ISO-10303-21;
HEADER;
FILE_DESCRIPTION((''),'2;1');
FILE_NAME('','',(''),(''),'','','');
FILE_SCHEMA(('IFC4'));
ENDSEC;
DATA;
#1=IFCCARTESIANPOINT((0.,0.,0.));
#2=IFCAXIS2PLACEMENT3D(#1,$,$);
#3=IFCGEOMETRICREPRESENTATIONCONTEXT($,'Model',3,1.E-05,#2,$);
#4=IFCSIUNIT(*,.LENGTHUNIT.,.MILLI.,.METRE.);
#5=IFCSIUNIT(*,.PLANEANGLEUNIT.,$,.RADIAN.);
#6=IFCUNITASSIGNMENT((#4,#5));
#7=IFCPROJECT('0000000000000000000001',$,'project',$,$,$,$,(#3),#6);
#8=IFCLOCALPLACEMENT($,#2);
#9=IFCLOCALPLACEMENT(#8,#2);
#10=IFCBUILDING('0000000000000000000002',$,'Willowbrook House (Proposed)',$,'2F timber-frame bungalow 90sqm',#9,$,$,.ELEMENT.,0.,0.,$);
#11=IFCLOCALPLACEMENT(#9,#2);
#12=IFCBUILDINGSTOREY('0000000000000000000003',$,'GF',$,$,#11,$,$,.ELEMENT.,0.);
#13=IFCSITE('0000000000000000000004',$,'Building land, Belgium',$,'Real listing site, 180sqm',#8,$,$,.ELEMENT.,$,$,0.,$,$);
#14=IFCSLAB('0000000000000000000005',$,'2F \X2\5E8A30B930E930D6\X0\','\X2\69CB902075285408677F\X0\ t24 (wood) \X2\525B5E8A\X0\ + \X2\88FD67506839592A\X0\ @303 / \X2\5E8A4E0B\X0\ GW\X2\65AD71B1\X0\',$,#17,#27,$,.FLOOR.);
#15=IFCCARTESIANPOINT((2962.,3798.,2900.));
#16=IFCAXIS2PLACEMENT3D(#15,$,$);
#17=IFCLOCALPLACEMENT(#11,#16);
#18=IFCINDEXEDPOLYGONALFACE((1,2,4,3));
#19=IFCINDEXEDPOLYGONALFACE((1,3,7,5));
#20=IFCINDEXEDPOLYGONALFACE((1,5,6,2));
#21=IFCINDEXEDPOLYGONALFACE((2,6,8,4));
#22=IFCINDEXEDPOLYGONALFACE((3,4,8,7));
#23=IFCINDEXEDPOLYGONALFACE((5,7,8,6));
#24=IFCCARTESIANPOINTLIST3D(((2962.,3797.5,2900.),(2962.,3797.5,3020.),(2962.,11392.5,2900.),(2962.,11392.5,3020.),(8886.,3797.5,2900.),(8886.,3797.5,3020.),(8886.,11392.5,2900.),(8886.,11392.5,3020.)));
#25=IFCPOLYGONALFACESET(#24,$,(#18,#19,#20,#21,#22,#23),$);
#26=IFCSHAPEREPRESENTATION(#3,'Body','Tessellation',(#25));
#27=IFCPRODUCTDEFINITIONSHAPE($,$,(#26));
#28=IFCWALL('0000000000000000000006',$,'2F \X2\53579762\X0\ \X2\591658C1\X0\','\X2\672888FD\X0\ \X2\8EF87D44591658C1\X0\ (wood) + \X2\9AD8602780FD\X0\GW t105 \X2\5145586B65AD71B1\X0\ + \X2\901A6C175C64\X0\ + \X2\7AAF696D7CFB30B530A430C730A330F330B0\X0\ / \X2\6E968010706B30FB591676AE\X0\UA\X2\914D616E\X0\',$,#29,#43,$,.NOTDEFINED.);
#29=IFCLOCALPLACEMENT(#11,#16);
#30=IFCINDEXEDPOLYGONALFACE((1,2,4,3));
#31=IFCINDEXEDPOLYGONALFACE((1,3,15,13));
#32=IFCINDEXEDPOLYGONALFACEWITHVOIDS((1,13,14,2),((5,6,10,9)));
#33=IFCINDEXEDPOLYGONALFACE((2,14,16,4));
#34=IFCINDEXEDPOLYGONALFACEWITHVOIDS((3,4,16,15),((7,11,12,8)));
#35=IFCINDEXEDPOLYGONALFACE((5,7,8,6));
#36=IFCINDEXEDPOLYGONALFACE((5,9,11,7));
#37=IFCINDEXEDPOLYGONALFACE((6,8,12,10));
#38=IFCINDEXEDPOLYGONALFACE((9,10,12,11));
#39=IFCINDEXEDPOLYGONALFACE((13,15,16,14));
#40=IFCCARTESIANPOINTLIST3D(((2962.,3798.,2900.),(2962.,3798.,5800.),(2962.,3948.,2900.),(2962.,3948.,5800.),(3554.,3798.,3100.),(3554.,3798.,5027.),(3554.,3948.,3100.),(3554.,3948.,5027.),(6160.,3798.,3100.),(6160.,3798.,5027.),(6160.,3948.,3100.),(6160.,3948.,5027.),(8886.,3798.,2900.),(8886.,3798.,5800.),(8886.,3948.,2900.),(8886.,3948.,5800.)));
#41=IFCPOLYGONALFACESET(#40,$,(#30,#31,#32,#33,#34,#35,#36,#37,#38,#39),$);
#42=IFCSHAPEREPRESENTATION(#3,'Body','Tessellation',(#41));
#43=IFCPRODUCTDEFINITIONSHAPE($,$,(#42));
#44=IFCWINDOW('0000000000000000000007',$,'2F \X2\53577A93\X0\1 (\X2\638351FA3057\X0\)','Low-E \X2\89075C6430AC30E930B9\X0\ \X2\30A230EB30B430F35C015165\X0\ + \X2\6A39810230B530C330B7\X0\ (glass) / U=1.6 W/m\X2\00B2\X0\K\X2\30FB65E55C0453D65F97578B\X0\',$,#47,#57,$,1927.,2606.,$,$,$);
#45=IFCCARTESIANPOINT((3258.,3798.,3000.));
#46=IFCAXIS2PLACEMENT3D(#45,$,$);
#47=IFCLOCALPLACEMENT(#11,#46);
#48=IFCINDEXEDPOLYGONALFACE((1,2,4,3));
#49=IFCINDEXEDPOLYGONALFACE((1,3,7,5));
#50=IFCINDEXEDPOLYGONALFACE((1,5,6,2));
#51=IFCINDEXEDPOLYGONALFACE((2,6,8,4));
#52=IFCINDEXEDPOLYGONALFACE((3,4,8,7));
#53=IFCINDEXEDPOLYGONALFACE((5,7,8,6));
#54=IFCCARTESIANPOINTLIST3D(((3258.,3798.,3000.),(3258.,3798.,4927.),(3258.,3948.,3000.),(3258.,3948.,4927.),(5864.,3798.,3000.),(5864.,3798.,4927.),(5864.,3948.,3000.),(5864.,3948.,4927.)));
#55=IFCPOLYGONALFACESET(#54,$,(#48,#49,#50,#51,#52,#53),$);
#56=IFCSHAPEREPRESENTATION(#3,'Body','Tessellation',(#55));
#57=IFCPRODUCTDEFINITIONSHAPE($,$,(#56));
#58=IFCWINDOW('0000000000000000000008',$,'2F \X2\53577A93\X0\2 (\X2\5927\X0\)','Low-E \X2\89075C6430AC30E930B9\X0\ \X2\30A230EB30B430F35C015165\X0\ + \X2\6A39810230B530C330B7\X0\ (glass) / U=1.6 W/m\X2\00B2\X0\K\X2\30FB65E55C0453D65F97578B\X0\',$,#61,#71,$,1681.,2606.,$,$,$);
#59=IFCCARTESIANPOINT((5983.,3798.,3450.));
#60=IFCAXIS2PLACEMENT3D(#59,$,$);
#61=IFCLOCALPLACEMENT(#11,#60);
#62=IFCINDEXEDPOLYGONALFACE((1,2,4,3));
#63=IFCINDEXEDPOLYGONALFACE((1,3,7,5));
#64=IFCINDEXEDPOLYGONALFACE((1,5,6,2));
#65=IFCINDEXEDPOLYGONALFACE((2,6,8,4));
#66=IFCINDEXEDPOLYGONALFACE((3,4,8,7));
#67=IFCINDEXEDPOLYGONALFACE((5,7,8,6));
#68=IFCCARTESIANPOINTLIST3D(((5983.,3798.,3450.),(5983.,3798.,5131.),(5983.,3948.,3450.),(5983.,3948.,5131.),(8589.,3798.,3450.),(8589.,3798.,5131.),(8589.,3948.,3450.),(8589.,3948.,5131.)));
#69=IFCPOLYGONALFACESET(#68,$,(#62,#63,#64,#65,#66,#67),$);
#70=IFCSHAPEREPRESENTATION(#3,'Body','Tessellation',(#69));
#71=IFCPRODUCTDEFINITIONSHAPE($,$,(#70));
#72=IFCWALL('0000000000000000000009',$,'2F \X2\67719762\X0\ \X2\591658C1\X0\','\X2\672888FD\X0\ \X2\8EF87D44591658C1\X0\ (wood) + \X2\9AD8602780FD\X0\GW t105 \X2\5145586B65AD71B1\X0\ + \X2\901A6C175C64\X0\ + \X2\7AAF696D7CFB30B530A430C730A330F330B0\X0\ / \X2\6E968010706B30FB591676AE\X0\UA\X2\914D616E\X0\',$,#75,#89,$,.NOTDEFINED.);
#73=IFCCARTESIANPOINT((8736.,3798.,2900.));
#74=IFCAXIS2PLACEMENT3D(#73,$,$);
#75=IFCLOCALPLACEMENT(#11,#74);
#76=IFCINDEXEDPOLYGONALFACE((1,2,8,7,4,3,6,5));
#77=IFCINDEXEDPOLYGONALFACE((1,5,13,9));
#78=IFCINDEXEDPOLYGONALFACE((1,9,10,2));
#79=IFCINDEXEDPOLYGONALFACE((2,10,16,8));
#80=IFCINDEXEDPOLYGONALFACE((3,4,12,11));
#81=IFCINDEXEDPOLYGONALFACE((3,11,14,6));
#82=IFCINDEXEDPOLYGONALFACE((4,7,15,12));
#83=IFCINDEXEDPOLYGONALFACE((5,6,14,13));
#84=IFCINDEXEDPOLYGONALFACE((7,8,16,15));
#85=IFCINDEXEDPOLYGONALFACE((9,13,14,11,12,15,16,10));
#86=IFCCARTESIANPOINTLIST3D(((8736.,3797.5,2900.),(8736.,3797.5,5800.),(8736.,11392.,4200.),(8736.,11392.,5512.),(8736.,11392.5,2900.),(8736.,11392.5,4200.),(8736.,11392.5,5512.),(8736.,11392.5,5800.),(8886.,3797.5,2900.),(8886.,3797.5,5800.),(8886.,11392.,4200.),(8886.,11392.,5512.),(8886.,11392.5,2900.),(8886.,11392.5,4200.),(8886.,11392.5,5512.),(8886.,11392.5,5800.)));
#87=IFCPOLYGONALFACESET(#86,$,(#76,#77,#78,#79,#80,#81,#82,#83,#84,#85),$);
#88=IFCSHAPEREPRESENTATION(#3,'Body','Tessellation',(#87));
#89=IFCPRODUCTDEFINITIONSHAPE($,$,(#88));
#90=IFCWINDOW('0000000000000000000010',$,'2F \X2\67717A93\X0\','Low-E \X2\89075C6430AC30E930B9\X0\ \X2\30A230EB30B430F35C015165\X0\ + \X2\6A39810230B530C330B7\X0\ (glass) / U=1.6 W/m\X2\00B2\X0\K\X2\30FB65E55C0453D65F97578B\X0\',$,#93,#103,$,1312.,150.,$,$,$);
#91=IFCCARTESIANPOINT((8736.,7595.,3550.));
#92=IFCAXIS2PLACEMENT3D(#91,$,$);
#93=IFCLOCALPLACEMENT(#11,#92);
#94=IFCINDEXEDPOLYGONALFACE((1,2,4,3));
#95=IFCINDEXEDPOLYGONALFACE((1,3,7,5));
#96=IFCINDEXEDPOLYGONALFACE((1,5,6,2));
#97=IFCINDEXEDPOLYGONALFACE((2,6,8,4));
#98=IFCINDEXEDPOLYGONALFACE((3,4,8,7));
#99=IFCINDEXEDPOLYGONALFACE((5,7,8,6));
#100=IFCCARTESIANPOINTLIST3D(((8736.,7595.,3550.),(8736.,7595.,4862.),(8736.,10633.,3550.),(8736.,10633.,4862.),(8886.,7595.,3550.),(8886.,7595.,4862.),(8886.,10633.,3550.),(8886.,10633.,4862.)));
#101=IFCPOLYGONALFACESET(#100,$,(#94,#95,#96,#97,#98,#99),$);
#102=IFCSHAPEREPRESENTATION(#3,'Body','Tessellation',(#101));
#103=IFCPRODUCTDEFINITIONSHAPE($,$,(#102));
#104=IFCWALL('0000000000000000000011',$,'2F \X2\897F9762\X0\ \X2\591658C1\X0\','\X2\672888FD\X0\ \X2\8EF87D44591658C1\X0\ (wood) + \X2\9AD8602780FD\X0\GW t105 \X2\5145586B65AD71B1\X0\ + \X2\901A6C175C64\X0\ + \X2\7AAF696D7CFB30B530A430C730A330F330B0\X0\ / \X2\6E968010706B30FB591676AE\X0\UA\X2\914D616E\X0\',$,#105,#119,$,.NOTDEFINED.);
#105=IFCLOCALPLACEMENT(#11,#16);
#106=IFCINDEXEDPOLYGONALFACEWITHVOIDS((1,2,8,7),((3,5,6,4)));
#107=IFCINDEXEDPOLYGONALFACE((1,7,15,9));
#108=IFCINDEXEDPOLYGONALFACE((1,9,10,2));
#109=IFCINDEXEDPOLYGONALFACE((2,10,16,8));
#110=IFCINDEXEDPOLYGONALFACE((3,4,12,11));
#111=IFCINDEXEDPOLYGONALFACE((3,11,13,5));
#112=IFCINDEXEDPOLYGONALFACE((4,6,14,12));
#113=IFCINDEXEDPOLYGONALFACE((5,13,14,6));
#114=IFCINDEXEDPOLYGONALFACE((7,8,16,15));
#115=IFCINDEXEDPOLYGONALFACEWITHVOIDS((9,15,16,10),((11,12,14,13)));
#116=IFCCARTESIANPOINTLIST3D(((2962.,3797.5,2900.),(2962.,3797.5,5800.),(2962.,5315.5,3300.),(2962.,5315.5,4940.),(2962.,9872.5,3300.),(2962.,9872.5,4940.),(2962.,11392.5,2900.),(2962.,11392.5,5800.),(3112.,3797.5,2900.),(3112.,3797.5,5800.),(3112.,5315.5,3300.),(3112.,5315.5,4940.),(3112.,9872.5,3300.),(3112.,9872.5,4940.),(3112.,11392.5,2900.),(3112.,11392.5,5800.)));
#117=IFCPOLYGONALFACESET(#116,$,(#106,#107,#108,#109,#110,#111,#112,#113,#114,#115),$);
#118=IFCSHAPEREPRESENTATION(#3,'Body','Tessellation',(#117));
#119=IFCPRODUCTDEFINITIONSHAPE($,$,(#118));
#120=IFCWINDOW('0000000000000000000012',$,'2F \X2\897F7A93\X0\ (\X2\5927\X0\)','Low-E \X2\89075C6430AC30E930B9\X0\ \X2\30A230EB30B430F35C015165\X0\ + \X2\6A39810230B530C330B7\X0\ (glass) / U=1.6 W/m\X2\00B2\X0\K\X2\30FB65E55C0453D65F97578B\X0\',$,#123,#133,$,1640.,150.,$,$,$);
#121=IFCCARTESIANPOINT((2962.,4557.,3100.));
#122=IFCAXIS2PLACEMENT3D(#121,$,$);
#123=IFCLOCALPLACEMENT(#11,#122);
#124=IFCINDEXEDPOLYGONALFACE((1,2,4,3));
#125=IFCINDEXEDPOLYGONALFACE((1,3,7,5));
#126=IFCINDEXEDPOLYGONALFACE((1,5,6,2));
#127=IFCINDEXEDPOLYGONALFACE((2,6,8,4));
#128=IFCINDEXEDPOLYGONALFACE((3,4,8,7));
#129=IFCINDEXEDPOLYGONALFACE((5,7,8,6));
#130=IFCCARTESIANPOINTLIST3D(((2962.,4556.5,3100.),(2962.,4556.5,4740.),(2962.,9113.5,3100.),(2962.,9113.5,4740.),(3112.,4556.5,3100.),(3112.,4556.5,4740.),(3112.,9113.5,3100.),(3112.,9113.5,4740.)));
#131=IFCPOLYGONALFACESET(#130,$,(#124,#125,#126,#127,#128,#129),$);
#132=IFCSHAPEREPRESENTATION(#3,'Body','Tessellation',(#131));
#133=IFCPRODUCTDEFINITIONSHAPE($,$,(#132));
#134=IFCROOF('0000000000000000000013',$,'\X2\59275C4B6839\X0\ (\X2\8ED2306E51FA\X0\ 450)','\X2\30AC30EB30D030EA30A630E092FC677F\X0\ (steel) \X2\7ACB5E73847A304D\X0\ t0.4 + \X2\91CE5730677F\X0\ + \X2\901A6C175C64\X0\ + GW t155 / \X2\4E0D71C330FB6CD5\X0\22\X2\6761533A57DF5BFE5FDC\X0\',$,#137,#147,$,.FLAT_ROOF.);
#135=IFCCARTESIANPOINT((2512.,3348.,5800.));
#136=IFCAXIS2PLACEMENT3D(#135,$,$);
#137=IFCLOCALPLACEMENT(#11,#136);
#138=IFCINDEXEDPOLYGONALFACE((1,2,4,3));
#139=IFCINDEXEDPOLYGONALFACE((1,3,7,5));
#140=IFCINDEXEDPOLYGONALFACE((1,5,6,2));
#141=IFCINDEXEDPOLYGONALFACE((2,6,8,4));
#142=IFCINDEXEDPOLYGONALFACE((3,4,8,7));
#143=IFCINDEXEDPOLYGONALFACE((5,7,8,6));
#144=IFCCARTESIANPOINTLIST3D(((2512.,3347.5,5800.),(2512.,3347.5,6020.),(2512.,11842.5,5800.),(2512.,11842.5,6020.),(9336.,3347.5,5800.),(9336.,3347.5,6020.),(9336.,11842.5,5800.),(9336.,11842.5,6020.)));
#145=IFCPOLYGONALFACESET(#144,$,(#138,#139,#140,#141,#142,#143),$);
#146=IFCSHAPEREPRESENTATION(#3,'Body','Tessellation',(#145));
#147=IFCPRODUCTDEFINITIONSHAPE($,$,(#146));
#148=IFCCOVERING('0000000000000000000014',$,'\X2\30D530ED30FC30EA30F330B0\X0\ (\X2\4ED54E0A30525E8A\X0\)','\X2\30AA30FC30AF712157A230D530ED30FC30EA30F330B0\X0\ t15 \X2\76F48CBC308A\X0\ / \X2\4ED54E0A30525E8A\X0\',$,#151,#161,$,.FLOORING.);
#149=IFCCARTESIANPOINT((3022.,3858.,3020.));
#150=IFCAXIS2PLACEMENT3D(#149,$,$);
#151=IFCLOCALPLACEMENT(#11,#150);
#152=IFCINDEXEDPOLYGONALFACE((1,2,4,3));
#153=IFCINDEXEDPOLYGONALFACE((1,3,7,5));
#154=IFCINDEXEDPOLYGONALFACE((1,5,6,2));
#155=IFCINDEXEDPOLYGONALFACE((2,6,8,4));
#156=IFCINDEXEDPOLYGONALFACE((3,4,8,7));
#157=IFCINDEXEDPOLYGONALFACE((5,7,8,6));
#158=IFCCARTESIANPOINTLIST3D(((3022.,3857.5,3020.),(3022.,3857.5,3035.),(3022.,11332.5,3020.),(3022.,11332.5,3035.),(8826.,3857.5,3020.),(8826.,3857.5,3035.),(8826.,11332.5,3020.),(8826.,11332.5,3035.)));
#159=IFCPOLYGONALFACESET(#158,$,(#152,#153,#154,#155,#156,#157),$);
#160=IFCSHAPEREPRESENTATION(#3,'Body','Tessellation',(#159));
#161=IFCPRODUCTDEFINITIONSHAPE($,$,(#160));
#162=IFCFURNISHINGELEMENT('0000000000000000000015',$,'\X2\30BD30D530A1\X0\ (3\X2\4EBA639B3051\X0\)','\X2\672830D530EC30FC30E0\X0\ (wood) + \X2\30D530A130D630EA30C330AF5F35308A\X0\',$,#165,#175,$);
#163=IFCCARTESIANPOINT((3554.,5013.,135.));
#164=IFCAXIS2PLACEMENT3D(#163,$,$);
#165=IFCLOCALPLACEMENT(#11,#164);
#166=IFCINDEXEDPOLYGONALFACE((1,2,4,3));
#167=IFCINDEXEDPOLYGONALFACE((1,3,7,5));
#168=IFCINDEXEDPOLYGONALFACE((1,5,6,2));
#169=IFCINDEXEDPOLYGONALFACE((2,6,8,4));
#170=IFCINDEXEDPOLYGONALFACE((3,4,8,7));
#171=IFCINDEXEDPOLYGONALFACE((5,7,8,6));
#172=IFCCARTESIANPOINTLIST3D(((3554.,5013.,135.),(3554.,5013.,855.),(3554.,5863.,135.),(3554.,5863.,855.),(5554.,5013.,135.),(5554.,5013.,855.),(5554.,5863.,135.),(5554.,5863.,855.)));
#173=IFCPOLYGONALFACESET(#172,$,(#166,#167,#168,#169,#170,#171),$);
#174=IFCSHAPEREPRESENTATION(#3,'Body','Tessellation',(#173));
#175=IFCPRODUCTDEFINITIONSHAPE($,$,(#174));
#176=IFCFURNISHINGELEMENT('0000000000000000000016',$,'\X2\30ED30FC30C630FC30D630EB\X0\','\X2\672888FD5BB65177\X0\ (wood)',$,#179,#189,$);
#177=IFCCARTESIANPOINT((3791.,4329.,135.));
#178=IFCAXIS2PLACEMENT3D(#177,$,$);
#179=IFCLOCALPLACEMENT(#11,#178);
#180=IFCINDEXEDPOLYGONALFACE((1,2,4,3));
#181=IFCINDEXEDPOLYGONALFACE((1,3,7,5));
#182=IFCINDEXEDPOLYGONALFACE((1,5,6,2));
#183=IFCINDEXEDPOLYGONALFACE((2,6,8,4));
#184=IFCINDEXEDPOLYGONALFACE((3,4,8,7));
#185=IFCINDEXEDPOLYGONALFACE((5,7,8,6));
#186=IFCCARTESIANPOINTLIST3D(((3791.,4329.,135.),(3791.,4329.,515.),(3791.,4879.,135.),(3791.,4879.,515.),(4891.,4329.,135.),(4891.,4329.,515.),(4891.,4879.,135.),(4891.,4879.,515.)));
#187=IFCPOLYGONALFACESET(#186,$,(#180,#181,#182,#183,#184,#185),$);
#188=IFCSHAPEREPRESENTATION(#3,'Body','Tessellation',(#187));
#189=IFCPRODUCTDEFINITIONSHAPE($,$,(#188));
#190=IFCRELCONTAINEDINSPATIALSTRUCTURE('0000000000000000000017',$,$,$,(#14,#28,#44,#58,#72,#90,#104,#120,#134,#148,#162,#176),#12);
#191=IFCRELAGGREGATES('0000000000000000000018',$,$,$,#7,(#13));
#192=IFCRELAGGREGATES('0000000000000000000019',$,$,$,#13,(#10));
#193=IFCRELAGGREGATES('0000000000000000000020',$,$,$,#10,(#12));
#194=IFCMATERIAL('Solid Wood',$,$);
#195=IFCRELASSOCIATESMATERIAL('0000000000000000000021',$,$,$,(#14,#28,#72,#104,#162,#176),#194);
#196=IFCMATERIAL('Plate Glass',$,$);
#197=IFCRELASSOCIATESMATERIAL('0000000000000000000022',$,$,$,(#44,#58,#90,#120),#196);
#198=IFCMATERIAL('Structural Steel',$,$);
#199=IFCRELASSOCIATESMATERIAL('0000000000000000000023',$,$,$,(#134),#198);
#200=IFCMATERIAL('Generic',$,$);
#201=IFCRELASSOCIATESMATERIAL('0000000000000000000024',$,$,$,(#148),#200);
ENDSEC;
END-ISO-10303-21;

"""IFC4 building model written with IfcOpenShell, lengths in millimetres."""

from ifc_helpers import new_model, si_unit, frame, frame_2d, origin, place, context, project, spatial, rectangle, extrude, material, element, fill, save


model = new_model("IFC4")

# Units and contexts
model_context = context("Model", 3, precision=1e-05, world=origin())
ifc_project = project(units=[si_unit("LENGTHUNIT", "METRE", prefix="MILLI"), si_unit("PLANEANGLEUNIT", "RADIAN")], contexts=[model_context])

# Site, building, storey
site_placement = place(None, origin())
site = spatial("IfcSite", under=ifc_project, at=site_placement, Name="Building land, Belgium", ObjectType="Real listing site, 180sqm", CompositionType="ELEMENT", RefElevation=0.0)
building_placement = place(site_placement, origin())
building = spatial("IfcBuilding", under=site, at=building_placement, Name="Willowbrook House (Proposed)", ObjectType="2F timber-frame bungalow 90sqm", CompositionType="ELEMENT", ElevationOfRefHeight=0.0, ElevationOfTerrain=0.0)
storey_placement = place(building_placement, origin())
storey = spatial("IfcBuildingStorey", under=building, at=storey_placement, Name="GF", CompositionType="ELEMENT", Elevation=0.0)

# Slab
ifc_material_1 = material(Name="Solid Wood")
slab_placement = place(storey_placement, frame((2962.0, 3798.0, 2900.0)))
element("IfcSlab", 1, at=slab_placement, inside=storey, material=ifc_material_1, Name="2F 床スラブ", Description="構造用合板 t24 (wood) 剛床 + 製材根太 @303 / 床下 GW断熱", PredefinedType="FLOOR", context=model_context, shape_type="SweptSolid", body=[
    extrude(rectangle(XDim=5924.0, YDim=7595.0, at=frame_2d((2962.0, 3797.0))), frame((2962.0, 3798.0, 2900.0)), (0.0, 0.0, 1.0), 120.0),
])

# Wall, openings, windows
wall_1_placement = place(storey_placement, frame((2962.0, 3798.0, 2900.0)))
wall_1 = element("IfcWall", 2, at=wall_1_placement, inside=storey, material=ifc_material_1, Name="2F 南面 外壁", Description="木製 軸組外壁 (wood) + 高性能GW t105 充填断熱 + 通気層 + 窯業系サイディング / 準耐火・外皮UA配慮", PredefinedType="NOTDEFINED", context=model_context, shape_type="SweptSolid", body=[
    extrude(rectangle(XDim=5924.0, YDim=150.0, at=frame_2d((2962.0, 75.0))), frame((2962.0, 3798.0, 2900.0)), (0.0, 0.0, 1.0), 2900.0),
])
opening_1_placement = place(storey_placement, frame((3258.0, 3798.0, 3000.0)))
opening_1 = element("IfcOpeningElement", 3, at=opening_1_placement, cuts=wall_1, PredefinedType="NOTDEFINED", context=model_context, shape_type="SweptSolid", body=[
    extrude(rectangle(XDim=2606.0, YDim=150.0, at=frame_2d((1303.0, 75.0))), frame((3258.0, 3798.0, 3000.0)), (0.0, 0.0, 1.0), 1927.0),
])
opening_2_placement = place(storey_placement, frame((5983.0, 3798.0, 3450.0)))
opening_2 = element("IfcOpeningElement", 4, at=opening_2_placement, cuts=wall_1, PredefinedType="NOTDEFINED", context=model_context, shape_type="SweptSolid", body=[
    extrude(rectangle(XDim=2606.0, YDim=150.0, at=frame_2d((1303.0, 75.0))), frame((5983.0, 3798.0, 3450.0)), (0.0, 0.0, 1.0), 1681.0),
])
ifc_material_2 = material(Name="Plate Glass")
window_1_placement = place(storey_placement, frame((3258.0, 3798.0, 3000.0)))
window_1 = element("IfcWindow", 5, at=window_1_placement, inside=storey, material=ifc_material_2, Name="2F 南窓1 (掃出し)", Description="Low-E 複層ガラス アルゴン封入 + 樹脂サッシ (glass) / U=1.6 W/m²K・日射取得型", OverallHeight=1927.0, OverallWidth=2606.0, context=model_context, shape_type="SweptSolid", body=[
    extrude(rectangle(XDim=2606.0, YDim=150.0, at=frame_2d((1303.0, 75.0))), frame((3258.0, 3798.0, 3000.0)), (0.0, 0.0, 1.0), 1927.0),
])
fill(opening_1, window_1)
window_2_placement = place(storey_placement, frame((5983.0, 3798.0, 3450.0)))
window_2 = element("IfcWindow", 6, at=window_2_placement, inside=storey, material=ifc_material_2, Name="2F 南窓2 (大)", Description="Low-E 複層ガラス アルゴン封入 + 樹脂サッシ (glass) / U=1.6 W/m²K・日射取得型", OverallHeight=1681.0, OverallWidth=2606.0, context=model_context, shape_type="SweptSolid", body=[
    extrude(rectangle(XDim=2606.0, YDim=150.0, at=frame_2d((1303.0, 75.0))), frame((5983.0, 3798.0, 3450.0)), (0.0, 0.0, 1.0), 1681.0),
])
fill(opening_2, window_2)

# Walls, openings, windows
wall_2_placement = place(storey_placement, frame((8736.0, 3798.0, 2900.0)))
wall_2 = element("IfcWall", 7, at=wall_2_placement, inside=storey, material=ifc_material_1, Name="2F 東面 外壁", Description="木製 軸組外壁 (wood) + 高性能GW t105 充填断熱 + 通気層 + 窯業系サイディング / 準耐火・外皮UA配慮", PredefinedType="NOTDEFINED", context=model_context, shape_type="SweptSolid", body=[
    extrude(rectangle(XDim=150.0, YDim=7595.0, at=frame_2d((75.0, 3797.0))), frame((8736.0, 3798.0, 2900.0)), (0.0, 0.0, 1.0), 2900.0),
])
opening_3_placement = place(storey_placement, frame((8736.0, 7595.0, 3550.0)))
opening_3 = element("IfcOpeningElement", 8, at=opening_3_placement, cuts=wall_2, PredefinedType="NOTDEFINED", context=model_context, shape_type="SweptSolid", body=[
    extrude(rectangle(XDim=150.0, YDim=3038.0, at=frame_2d((75.0, 1519.0))), frame((8736.0, 7595.0, 3550.0)), (0.0, 0.0, 1.0), 1312.0),
])
window_3_placement = place(storey_placement, frame((8736.0, 7595.0, 3550.0)))
window_3 = element("IfcWindow", 9, at=window_3_placement, inside=storey, material=ifc_material_2, Name="2F 東窓", Description="Low-E 複層ガラス アルゴン封入 + 樹脂サッシ (glass) / U=1.6 W/m²K・日射取得型", OverallHeight=1312.0, OverallWidth=150.0, context=model_context, shape_type="SweptSolid", body=[
    extrude(rectangle(XDim=150.0, YDim=3038.0, at=frame_2d((75.0, 1519.0))), frame((8736.0, 7595.0, 3550.0)), (0.0, 0.0, 1.0), 1312.0),
])
fill(opening_3, window_3)
wall_3_placement = place(storey_placement, frame((2962.0, 3798.0, 2900.0)))
wall_3 = element("IfcWall", 10, at=wall_3_placement, inside=storey, material=ifc_material_1, Name="2F 西面 外壁", Description="木製 軸組外壁 (wood) + 高性能GW t105 充填断熱 + 通気層 + 窯業系サイディング / 準耐火・外皮UA配慮", PredefinedType="NOTDEFINED", context=model_context, shape_type="SweptSolid", body=[
    extrude(rectangle(XDim=150.0, YDim=7595.0, at=frame_2d((75.0, 3797.0))), frame((2962.0, 3798.0, 2900.0)), (0.0, 0.0, 1.0), 2900.0),
])
opening_4_placement = place(storey_placement, frame((2962.0, 4557.0, 3100.0)))
opening_4 = element("IfcOpeningElement", 11, at=opening_4_placement, cuts=wall_3, PredefinedType="NOTDEFINED", context=model_context, shape_type="SweptSolid", body=[
    extrude(rectangle(XDim=150.0, YDim=4557.0, at=frame_2d((75.0, 2278.0))), frame((2962.0, 4557.0, 3100.0)), (0.0, 0.0, 1.0), 1640.0),
])
window_4_placement = place(storey_placement, frame((2962.0, 4557.0, 3100.0)))
window_4 = element("IfcWindow", 12, at=window_4_placement, inside=storey, material=ifc_material_2, Name="2F 西窓 (大)", Description="Low-E 複層ガラス アルゴン封入 + 樹脂サッシ (glass) / U=1.6 W/m²K・日射取得型", OverallHeight=1640.0, OverallWidth=150.0, context=model_context, shape_type="SweptSolid", body=[
    extrude(rectangle(XDim=150.0, YDim=4557.0, at=frame_2d((75.0, 2278.0))), frame((2962.0, 4557.0, 3100.0)), (0.0, 0.0, 1.0), 1640.0),
])
fill(opening_4, window_4)

# Roof
ifc_material_3 = material(Name="Structural Steel")
roof_placement = place(storey_placement, frame((2512.0, 3348.0, 5800.0)))
element("IfcRoof", 13, at=roof_placement, inside=storey, material=ifc_material_3, Name="大屋根 (軒の出 450)", Description="ガルバリウム鋼板 (steel) 立平葺き t0.4 + 野地板 + 通気層 + GW t155 / 不燃・法22条区域対応", PredefinedType="FLAT_ROOF", context=model_context, shape_type="SweptSolid", body=[
    extrude(rectangle(XDim=6824.0, YDim=8495.0, at=frame_2d((3412.0, 4247.0))), frame((2512.0, 3348.0, 5800.0)), (0.0, 0.0, 1.0), 220.0),
])

# Covering
ifc_material_4 = material(Name="Generic")
covering_placement = place(storey_placement, frame((3022.0, 3858.0, 3020.0)))
element("IfcCovering", 14, at=covering_placement, inside=storey, material=ifc_material_4, Name="フローリング (仕上げ床)", Description="オーク無垢フローリング t15 直貼り / 仕上げ床", PredefinedType="FLOORING", context=model_context, shape_type="SweptSolid", body=[
    extrude(rectangle(XDim=5804.0, YDim=7475.0, at=frame_2d((2902.0, 3737.0))), frame((3022.0, 3858.0, 3020.0)), (0.0, 0.0, 1.0), 15.0),
])

# Furnishing elements
furnishing_1_placement = place(storey_placement, frame((3554.0, 5013.0, 135.0)))
element("IfcFurnishingElement", 15, at=furnishing_1_placement, inside=storey, material=ifc_material_1, Name="ソファ (3人掛け)", Description="木フレーム (wood) + ファブリック張り", context=model_context, shape_type="SweptSolid", body=[
    extrude(rectangle(XDim=2000.0, YDim=850.0, at=frame_2d((1000.0, 425.0))), frame((3554.0, 5013.0, 135.0)), (0.0, 0.0, 1.0), 720.0),
])
furnishing_2_placement = place(storey_placement, frame((3791.0, 4329.0, 135.0)))
element("IfcFurnishingElement", 16, at=furnishing_2_placement, inside=storey, material=ifc_material_1, Name="ローテーブル", Description="木製家具 (wood)", context=model_context, shape_type="SweptSolid", body=[
    extrude(rectangle(XDim=1100.0, YDim=550.0, at=frame_2d((550.0, 275.0))), frame((3791.0, 4329.0, 135.0)), (0.0, 0.0, 1.0), 380.0),
])

save(model, "model.ifc")
